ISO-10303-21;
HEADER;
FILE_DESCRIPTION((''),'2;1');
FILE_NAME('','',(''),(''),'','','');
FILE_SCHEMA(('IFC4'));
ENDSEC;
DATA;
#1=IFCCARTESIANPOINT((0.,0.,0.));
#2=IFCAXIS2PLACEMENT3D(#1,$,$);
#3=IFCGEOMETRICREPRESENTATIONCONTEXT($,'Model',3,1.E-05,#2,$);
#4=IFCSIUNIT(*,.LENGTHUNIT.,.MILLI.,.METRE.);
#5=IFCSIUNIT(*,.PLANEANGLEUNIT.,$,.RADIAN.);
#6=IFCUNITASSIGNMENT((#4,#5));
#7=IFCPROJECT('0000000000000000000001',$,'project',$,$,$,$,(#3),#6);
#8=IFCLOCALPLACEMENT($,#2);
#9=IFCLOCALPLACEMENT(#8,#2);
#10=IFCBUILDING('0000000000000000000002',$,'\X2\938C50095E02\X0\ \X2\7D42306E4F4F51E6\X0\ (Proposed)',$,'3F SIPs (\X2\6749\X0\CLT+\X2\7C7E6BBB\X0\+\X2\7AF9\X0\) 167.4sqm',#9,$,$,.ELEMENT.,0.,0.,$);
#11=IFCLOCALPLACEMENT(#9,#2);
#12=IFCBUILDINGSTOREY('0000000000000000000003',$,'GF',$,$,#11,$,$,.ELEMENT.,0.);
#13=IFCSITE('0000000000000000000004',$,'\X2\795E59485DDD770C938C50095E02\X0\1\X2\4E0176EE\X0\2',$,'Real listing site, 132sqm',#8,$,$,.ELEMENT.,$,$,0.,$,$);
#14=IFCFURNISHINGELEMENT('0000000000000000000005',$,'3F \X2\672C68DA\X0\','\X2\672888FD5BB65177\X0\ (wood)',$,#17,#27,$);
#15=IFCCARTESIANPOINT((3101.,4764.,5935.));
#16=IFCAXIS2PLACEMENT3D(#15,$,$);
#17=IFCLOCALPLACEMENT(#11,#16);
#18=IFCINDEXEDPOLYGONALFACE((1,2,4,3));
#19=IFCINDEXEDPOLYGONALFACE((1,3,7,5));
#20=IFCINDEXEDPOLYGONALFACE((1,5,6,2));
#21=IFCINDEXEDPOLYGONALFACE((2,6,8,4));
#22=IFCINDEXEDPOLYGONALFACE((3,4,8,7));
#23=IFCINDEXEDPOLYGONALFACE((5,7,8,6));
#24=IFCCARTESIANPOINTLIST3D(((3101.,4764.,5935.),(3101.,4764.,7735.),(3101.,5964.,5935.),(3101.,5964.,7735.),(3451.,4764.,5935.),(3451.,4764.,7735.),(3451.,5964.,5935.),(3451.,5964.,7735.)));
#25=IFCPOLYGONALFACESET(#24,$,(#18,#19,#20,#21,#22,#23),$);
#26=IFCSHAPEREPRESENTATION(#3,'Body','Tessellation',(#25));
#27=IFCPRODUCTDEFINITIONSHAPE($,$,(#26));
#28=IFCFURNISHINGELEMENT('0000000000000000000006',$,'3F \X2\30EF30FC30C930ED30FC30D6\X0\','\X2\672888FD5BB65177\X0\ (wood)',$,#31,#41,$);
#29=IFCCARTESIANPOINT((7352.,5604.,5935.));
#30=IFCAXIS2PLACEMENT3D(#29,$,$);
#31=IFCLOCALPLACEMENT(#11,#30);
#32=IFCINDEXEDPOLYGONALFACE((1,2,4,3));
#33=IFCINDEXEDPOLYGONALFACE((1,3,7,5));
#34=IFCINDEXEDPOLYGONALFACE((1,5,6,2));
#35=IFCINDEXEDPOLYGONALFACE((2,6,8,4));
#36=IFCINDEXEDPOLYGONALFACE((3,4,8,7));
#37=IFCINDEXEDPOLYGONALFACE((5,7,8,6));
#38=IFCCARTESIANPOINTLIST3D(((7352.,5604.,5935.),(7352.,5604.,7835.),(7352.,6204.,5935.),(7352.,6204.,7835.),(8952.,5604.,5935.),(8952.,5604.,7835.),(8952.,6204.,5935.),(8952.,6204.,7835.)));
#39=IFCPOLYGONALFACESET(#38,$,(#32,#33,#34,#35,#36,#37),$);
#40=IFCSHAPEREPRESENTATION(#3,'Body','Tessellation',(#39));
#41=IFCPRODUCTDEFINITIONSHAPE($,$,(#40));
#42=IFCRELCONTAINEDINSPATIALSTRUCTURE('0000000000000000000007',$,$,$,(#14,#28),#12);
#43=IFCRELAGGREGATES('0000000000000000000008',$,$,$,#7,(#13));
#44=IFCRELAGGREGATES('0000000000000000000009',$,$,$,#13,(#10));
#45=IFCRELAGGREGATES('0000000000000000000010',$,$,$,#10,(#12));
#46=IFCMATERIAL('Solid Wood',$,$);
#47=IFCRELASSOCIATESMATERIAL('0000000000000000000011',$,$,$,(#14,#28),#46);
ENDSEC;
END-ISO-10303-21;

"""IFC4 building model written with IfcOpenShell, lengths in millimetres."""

from ifc_helpers import new_model, si_unit, frame, frame_2d, origin, place, context, project, spatial, rectangle, extrude, material, element, save


model = new_model("IFC4")

# Units and contexts
model_context = context("Model", 3, precision=1e-05, world=origin())
ifc_project = project(units=[si_unit("LENGTHUNIT", "METRE", prefix="MILLI"), si_unit("PLANEANGLEUNIT", "RADIAN")], contexts=[model_context])

# Site, building, storey
site_placement = place(None, origin())
site = spatial("IfcSite", under=ifc_project, at=site_placement, Name="神奈川県鎌倉市1丁目2", ObjectType="Real listing site, 132sqm", CompositionType="ELEMENT", RefElevation=0.0)
building_placement = place(site_placement, origin())
building = spatial("IfcBuilding", under=site, at=building_placement, Name="鎌倉市 終の住処 (Proposed)", ObjectType="3F SIPs (杉CLT+籾殻+竹) 167.4sqm", CompositionType="ELEMENT", ElevationOfRefHeight=0.0, ElevationOfTerrain=0.0)
storey_placement = place(building_placement, origin())
storey = spatial("IfcBuildingStorey", under=building, at=storey_placement, Name="GF", CompositionType="ELEMENT", Elevation=0.0)

# Shared definitions
ifc_material_1 = material(Name="Solid Wood")

# Furnishing elements
furnishing_1_placement = place(storey_placement, frame((3101.0, 4764.0, 5935.0)))
element("IfcFurnishingElement", 1, at=furnishing_1_placement, inside=storey, material=ifc_material_1, Name="3F 本棚", Description="木製家具 (wood)", context=model_context, shape_type="SweptSolid", body=[
    extrude(rectangle(XDim=350.0, YDim=1200.0, at=frame_2d((175.0, 600.0))), frame((3101.0, 4764.0, 5935.0)), (0.0, 0.0, 1.0), 1800.0),
])
furnishing_2_placement = place(storey_placement, frame((7352.0, 5604.0, 5935.0)))
element("IfcFurnishingElement", 2, at=furnishing_2_placement, inside=storey, material=ifc_material_1, Name="3F ワードローブ", Description="木製家具 (wood)", context=model_context, shape_type="SweptSolid", body=[
    extrude(rectangle(XDim=1600.0, YDim=600.0, at=frame_2d((800.0, 300.0))), frame((7352.0, 5604.0, 5935.0)), (0.0, 0.0, 1.0), 1900.0),
])

save(model, "model.ifc")
